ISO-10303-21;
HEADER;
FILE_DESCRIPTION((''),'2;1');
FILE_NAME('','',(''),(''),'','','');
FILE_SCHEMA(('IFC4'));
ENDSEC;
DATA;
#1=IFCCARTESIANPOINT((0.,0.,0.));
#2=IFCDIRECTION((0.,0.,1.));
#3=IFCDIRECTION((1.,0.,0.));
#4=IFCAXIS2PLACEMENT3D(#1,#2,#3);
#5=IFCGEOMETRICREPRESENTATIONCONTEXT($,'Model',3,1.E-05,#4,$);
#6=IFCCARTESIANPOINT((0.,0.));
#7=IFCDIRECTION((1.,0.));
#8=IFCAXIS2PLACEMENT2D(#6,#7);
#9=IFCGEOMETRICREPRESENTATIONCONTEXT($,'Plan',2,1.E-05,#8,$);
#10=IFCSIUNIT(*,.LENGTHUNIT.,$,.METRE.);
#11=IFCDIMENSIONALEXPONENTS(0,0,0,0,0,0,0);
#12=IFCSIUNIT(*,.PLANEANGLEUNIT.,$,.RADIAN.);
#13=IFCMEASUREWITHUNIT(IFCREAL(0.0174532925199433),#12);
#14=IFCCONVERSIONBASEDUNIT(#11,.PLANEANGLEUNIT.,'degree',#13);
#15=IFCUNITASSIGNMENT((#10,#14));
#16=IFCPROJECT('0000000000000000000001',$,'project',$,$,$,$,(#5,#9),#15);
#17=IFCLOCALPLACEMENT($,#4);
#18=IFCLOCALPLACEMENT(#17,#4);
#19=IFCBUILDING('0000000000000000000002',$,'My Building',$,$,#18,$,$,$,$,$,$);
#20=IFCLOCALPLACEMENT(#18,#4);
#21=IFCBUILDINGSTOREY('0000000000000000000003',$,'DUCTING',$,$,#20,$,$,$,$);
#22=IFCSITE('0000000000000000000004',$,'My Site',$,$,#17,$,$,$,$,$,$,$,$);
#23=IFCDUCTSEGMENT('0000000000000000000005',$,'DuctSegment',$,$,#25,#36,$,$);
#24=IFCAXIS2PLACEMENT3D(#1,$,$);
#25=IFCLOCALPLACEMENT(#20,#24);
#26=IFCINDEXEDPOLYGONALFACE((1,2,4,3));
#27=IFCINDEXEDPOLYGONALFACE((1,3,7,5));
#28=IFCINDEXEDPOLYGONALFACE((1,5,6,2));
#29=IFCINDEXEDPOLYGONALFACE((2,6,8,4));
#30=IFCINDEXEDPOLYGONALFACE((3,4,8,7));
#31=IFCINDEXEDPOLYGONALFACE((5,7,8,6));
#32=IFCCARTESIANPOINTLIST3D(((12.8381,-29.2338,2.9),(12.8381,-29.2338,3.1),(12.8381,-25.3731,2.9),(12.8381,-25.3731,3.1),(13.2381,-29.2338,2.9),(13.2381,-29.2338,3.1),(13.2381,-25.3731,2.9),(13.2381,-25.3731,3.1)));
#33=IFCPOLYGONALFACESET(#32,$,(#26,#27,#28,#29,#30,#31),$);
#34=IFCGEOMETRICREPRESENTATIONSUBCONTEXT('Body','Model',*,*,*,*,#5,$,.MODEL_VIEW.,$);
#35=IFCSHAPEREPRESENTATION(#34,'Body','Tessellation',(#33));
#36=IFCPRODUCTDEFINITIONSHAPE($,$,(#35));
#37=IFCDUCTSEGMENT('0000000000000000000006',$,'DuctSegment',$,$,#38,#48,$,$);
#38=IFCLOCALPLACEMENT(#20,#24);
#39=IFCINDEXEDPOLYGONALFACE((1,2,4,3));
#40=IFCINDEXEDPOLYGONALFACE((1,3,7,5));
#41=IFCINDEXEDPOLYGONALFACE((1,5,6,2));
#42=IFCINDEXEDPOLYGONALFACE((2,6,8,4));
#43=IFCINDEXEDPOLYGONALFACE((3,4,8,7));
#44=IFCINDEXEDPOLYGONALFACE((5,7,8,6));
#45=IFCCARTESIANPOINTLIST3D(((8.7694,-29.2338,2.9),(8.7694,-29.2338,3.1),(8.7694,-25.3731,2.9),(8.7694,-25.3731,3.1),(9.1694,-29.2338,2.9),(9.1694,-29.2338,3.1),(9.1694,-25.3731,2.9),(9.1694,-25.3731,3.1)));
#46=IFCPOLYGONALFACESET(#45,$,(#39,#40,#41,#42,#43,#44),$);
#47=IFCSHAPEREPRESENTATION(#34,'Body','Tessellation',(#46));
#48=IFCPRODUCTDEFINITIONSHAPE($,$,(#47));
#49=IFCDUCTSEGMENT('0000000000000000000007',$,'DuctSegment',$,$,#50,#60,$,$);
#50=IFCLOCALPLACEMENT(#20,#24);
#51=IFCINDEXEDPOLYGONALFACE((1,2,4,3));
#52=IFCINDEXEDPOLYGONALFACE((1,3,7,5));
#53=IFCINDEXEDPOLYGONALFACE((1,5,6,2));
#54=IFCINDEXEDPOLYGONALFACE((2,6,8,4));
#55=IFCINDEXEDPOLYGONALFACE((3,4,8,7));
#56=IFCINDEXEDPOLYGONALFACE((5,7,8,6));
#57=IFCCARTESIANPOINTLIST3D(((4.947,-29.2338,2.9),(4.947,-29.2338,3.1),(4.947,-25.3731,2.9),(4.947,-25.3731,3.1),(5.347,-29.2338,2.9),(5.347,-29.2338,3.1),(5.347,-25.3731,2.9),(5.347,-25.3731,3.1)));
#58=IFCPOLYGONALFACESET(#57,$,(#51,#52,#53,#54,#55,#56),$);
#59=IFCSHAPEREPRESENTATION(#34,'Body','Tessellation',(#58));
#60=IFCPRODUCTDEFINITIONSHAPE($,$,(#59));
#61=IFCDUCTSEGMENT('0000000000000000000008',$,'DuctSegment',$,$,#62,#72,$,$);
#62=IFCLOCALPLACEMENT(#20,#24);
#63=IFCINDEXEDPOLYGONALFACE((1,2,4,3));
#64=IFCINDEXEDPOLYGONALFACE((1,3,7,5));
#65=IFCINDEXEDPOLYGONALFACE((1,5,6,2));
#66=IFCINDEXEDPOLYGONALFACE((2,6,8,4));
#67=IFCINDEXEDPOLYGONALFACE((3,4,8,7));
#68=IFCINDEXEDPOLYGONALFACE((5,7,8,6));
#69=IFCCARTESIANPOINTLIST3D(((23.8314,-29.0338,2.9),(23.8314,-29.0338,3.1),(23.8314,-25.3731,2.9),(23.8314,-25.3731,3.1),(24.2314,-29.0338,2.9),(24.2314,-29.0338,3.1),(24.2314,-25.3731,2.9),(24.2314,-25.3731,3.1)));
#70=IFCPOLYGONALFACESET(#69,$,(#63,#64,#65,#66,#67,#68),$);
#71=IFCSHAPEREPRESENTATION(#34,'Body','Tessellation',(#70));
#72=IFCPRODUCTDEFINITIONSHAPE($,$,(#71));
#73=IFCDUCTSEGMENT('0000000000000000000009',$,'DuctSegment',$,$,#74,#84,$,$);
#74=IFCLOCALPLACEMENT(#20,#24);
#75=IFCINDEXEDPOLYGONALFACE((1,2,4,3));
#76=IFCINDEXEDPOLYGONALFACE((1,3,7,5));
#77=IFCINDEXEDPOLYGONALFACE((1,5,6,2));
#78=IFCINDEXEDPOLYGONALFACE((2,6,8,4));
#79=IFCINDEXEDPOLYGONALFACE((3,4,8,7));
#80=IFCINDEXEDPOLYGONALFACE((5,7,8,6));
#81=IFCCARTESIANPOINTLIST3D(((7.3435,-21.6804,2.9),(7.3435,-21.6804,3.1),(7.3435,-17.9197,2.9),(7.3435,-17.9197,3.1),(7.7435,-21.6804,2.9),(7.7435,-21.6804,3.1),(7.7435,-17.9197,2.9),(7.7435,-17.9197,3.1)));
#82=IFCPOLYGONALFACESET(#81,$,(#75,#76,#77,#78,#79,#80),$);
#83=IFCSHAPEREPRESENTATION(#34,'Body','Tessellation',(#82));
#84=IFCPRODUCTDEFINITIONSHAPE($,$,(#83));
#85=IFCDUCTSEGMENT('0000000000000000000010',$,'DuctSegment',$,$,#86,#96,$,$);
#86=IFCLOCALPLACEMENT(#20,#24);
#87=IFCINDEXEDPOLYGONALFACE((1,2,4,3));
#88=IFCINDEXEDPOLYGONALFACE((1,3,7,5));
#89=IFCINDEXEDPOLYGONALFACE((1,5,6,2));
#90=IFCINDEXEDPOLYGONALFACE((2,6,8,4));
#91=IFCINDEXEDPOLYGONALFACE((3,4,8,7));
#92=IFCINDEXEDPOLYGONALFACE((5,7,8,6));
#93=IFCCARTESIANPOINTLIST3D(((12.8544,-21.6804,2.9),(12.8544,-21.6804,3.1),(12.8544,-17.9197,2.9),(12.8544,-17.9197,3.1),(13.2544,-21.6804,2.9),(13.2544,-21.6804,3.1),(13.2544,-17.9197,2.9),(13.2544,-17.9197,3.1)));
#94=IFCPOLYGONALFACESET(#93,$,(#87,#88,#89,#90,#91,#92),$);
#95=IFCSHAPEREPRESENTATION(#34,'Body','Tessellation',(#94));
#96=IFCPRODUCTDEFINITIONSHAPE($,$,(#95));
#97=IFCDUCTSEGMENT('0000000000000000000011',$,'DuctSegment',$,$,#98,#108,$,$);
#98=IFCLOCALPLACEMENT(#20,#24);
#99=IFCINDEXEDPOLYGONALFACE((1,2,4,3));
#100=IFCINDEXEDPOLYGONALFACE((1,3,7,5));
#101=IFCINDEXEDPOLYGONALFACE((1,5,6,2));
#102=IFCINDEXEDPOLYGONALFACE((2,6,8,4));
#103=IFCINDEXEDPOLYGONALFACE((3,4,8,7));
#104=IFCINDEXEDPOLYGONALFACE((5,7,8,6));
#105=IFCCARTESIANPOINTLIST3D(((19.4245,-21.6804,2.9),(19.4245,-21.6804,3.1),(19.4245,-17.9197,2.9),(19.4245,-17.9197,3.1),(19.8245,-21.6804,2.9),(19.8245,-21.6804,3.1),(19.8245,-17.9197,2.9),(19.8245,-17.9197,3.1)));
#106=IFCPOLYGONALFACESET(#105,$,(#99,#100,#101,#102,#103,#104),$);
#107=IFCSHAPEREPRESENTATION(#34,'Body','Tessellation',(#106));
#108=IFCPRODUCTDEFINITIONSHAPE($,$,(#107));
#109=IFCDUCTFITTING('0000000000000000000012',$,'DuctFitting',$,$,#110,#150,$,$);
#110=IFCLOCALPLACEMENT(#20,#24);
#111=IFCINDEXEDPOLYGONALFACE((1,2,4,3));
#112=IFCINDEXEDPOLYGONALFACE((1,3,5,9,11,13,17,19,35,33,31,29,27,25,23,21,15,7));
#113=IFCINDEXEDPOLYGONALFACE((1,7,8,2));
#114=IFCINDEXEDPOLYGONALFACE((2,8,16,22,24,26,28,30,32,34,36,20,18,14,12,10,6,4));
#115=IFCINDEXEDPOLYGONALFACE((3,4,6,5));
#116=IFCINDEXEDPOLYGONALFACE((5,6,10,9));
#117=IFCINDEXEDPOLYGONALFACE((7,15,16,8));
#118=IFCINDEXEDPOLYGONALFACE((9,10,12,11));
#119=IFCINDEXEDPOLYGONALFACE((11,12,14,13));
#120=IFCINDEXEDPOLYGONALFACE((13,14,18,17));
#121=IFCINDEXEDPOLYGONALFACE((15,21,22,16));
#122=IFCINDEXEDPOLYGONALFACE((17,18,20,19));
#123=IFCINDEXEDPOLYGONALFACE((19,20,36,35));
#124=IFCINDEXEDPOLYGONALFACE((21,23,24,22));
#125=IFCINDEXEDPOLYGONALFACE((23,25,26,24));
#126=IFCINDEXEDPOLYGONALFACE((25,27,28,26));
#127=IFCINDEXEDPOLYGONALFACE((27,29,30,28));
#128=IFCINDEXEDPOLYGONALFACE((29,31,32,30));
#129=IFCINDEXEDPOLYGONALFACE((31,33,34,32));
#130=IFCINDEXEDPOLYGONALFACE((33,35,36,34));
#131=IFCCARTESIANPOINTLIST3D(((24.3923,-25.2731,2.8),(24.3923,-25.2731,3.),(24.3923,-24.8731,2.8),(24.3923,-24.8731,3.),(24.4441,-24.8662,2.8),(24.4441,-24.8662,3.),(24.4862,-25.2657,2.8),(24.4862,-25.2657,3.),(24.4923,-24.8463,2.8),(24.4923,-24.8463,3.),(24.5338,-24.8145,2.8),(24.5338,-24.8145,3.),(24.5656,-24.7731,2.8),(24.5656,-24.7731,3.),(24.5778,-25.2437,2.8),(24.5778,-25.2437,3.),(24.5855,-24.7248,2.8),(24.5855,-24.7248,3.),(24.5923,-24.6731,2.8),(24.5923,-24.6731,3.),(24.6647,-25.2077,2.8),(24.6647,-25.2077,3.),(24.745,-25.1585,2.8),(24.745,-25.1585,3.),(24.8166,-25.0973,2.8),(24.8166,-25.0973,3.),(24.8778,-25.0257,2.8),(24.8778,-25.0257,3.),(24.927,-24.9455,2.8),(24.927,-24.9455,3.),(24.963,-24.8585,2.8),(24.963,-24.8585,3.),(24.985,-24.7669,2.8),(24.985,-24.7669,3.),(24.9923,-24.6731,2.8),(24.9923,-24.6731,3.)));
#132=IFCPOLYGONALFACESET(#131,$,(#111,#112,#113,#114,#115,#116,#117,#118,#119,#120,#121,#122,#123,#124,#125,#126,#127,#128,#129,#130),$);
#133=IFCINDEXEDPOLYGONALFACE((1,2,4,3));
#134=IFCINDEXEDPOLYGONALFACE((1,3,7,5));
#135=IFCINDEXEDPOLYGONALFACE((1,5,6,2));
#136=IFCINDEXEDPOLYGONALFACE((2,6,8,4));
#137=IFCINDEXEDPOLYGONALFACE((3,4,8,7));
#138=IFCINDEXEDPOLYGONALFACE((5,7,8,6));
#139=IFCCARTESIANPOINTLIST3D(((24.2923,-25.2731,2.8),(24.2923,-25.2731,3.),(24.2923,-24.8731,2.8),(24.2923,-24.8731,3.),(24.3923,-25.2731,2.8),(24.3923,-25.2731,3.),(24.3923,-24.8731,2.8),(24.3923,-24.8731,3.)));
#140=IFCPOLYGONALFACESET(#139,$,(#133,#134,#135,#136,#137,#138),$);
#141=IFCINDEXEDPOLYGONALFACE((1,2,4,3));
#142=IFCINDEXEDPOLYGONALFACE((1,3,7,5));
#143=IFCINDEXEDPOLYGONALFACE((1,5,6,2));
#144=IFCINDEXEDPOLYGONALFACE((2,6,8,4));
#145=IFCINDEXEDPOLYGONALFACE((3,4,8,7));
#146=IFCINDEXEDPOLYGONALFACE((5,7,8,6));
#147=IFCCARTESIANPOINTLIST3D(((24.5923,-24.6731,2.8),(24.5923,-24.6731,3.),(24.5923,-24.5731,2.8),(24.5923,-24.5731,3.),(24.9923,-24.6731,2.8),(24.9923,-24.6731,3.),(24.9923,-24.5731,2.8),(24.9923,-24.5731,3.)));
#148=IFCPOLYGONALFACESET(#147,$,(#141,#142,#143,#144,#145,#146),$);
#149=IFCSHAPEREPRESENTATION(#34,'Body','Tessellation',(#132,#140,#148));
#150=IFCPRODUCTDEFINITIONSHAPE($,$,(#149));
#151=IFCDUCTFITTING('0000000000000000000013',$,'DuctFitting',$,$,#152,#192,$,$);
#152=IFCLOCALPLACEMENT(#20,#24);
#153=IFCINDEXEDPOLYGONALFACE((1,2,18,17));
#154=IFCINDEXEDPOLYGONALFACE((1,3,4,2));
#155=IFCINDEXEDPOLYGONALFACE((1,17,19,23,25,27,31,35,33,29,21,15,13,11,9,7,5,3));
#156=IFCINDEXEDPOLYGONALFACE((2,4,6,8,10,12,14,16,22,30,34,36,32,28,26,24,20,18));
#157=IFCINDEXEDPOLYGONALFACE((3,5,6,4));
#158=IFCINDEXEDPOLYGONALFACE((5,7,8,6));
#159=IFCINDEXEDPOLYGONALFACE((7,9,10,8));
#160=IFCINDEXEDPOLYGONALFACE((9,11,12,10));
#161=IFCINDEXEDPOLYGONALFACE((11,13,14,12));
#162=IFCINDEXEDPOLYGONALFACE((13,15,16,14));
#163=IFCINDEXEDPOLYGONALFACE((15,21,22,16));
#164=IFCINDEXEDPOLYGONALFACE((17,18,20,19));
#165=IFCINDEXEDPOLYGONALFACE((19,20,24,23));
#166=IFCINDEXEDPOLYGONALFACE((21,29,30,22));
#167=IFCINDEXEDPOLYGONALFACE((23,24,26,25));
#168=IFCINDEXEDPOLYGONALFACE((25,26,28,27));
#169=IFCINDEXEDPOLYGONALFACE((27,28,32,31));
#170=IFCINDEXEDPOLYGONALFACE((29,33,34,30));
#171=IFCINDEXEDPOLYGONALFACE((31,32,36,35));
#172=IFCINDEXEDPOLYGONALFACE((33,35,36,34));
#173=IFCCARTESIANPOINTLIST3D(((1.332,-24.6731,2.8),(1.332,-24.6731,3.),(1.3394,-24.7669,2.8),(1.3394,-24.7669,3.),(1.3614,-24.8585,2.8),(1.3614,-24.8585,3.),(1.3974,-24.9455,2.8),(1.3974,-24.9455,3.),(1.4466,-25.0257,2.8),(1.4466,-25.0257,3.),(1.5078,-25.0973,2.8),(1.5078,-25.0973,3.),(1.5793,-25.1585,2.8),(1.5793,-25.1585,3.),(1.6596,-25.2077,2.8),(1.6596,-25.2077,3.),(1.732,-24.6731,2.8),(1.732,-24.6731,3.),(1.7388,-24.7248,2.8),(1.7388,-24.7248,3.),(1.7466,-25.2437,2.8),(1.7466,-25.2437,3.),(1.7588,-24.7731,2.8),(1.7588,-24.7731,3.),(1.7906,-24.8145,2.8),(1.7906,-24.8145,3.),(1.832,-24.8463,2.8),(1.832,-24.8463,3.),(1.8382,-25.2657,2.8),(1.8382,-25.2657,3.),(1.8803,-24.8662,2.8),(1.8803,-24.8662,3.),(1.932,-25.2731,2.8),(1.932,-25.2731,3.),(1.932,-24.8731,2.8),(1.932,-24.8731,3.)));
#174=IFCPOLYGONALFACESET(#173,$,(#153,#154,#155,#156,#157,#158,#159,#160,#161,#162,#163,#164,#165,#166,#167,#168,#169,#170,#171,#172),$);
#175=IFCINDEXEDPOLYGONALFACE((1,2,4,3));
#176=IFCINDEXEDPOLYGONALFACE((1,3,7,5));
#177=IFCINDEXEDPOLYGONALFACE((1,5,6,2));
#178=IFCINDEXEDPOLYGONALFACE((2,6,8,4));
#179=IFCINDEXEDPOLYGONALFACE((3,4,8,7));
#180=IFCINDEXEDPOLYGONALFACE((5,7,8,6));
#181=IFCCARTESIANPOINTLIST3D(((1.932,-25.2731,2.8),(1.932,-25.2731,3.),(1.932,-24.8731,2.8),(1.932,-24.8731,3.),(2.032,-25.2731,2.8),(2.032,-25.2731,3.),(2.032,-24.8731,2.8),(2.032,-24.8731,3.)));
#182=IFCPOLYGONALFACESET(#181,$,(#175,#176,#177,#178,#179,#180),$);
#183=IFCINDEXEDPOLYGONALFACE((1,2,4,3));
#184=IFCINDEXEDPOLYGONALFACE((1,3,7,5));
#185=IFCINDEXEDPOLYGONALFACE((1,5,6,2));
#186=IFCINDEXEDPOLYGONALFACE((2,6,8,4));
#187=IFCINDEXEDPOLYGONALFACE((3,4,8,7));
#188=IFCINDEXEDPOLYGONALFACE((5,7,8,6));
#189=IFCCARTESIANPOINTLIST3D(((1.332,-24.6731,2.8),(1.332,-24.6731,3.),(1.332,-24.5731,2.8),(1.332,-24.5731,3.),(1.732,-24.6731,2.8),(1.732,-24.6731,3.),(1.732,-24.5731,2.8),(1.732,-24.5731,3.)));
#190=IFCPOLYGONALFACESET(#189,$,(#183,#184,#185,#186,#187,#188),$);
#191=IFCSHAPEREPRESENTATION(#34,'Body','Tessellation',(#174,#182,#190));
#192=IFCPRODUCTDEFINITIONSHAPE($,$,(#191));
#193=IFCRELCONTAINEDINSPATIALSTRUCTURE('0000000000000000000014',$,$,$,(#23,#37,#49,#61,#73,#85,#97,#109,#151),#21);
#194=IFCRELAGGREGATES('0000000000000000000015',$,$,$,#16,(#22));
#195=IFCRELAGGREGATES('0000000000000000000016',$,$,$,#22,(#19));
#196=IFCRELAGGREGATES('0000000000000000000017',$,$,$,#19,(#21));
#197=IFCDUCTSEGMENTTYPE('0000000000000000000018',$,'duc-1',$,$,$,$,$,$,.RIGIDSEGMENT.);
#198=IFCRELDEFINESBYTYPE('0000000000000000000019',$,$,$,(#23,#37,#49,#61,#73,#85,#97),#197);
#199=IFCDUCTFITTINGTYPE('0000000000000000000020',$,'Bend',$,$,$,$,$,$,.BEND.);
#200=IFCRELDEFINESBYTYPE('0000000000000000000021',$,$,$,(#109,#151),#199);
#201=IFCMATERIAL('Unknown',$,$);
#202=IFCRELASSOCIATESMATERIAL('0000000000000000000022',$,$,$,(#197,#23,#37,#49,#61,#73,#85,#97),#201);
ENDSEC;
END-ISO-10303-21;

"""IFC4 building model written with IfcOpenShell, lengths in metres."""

from ifc_helpers import new_model, entity, si_unit, converted_unit, frame, origin_with_axes, origin_2d_with_axis, place, context, subcontext, project, spatial, line, arc, indexed_curve, rectangle, outline, extrude, source, transform, mapped, material, material_profile, profile_set, profile_usage, type_object, type_shapes, element, save


model = new_model("IFC4")

# Units and contexts
model_context = context("Model", 3, precision=1e-05, world=origin_with_axes())
plan_context = context("Plan", 2, precision=1e-05, world=origin_2d_with_axis())
body_context = subcontext(model_context, "Body", "Model", "MODEL_VIEW")
ifc_project = project(units=[si_unit("LENGTHUNIT", "METRE"), converted_unit("PLANEANGLEUNIT", "degree", entity("IfcReal", 0.0174532925199433), si_unit("PLANEANGLEUNIT", "RADIAN"), dimensions=[0, 0, 0, 0, 0, 0, 0])], contexts=[model_context, plan_context])

# Site, building, storey
site_placement = place(None, origin_with_axes())
site = spatial("IfcSite", under=ifc_project, at=site_placement, Name="My Site")
building_placement = place(site_placement, origin_with_axes())
building = spatial("IfcBuilding", under=site, at=building_placement, Name="My Building")
storey_placement = place(building_placement, origin_with_axes())
storey = spatial("IfcBuildingStorey", under=building, at=storey_placement, Name="DUCTING")

# Duct segments
ifc_material = material(Name="Unknown")
ifc_material_profile_1 = material_profile(ifc_material, rectangle(XDim=0.4, YDim=0.2))
ifc_profile_set_1 = profile_set([ifc_material_profile_1])
duct_segment_type = type_object("IfcDuctSegmentType", Name="duc-1", PredefinedType="RIGIDSEGMENT", material=ifc_profile_set_1)
ifc_profile_usage_1 = profile_usage(ifc_profile_set_1, cardinal=5)
duct_segment_1_placement = place(storey_placement, frame((13.0381, -29.2338, 3.0), z_axis=(0.0, 1.0, 0.0), x_axis=(-1.0, 0.0, 0.0)))
element("IfcDuctSegment", 1, at=duct_segment_1_placement, inside=storey, type_object=duct_segment_type, material=ifc_profile_usage_1, Name="DuctSegment", context=body_context, shape_type="SweptSolid", body=[
    extrude(rectangle(XDim=0.4, YDim=0.2), origin_with_axes(), (0.0, 0.0, 1.0), 3.8608),
])
ifc_profile_usage_2 = profile_usage(ifc_profile_set_1, cardinal=5)
duct_segment_2_placement = place(storey_placement, frame((8.9694, -29.2338, 3.0), z_axis=(0.0, 1.0, 0.0), x_axis=(-1.0, 0.0, 0.0)))
element("IfcDuctSegment", 2, at=duct_segment_2_placement, inside=storey, type_object=duct_segment_type, material=ifc_profile_usage_2, Name="DuctSegment", context=body_context, shape_type="SweptSolid", body=[
    extrude(rectangle(XDim=0.4, YDim=0.2), origin_with_axes(), (0.0, 0.0, 1.0), 3.8608),
])
ifc_profile_usage_3 = profile_usage(ifc_profile_set_1, cardinal=5)
duct_segment_3_placement = place(storey_placement, frame((5.147, -29.2338, 3.0), z_axis=(0.0, 1.0, 0.0), x_axis=(-1.0, 0.0, 0.0)))
element("IfcDuctSegment", 3, at=duct_segment_3_placement, inside=storey, type_object=duct_segment_type, material=ifc_profile_usage_3, Name="DuctSegment", context=body_context, shape_type="SweptSolid", body=[
    extrude(rectangle(XDim=0.4, YDim=0.2), origin_with_axes(), (0.0, 0.0, 1.0), 3.8608),
])
ifc_profile_usage_4 = profile_usage(ifc_profile_set_1, cardinal=5)
duct_segment_4_placement = place(storey_placement, frame((24.0314, -29.0338, 3.0), z_axis=(0.0, 1.0, 0.0), x_axis=(-1.0, 0.0, 0.0)))
element("IfcDuctSegment", 4, at=duct_segment_4_placement, inside=storey, type_object=duct_segment_type, material=ifc_profile_usage_4, Name="DuctSegment", context=body_context, shape_type="SweptSolid", body=[
    extrude(rectangle(XDim=0.4, YDim=0.2), origin_with_axes(), (0.0, 0.0, 1.0), 3.6608),
])
ifc_profile_usage_5 = profile_usage(ifc_profile_set_1, cardinal=5)
duct_segment_5_placement = place(storey_placement, frame((7.5435, -21.6804, 3.0), z_axis=(0.0, 1.0, 0.0), x_axis=(-1.0, 0.0, 0.0)))
element("IfcDuctSegment", 5, at=duct_segment_5_placement, inside=storey, type_object=duct_segment_type, material=ifc_profile_usage_5, Name="DuctSegment", context=body_context, shape_type="SweptSolid", body=[
    extrude(rectangle(XDim=0.4, YDim=0.2), origin_with_axes(), (0.0, 0.0, 1.0), 3.7608),
])
ifc_profile_usage_6 = profile_usage(ifc_profile_set_1, cardinal=5)
duct_segment_6_placement = place(storey_placement, frame((13.0544, -21.6804, 3.0), z_axis=(0.0, 1.0, 0.0), x_axis=(-1.0, 0.0, 0.0)))
element("IfcDuctSegment", 6, at=duct_segment_6_placement, inside=storey, type_object=duct_segment_type, material=ifc_profile_usage_6, Name="DuctSegment", context=body_context, shape_type="SweptSolid", body=[
    extrude(rectangle(XDim=0.4, YDim=0.2), origin_with_axes(), (0.0, 0.0, 1.0), 3.7608),
])
ifc_profile_usage_7 = profile_usage(ifc_profile_set_1, cardinal=5)
duct_segment_7_placement = place(storey_placement, frame((19.6245, -21.6804, 3.0), z_axis=(0.0, 1.0, 0.0), x_axis=(-1.0, 0.0, 0.0)))
element("IfcDuctSegment", 7, at=duct_segment_7_placement, inside=storey, type_object=duct_segment_type, material=ifc_profile_usage_7, Name="DuctSegment", context=body_context, shape_type="SweptSolid", body=[
    extrude(rectangle(XDim=0.4, YDim=0.2), origin_with_axes(), (0.0, 0.0, 1.0), 3.7608),
])

# Duct fittings
duct_fitting_type_1 = type_object("IfcDuctFittingType", Name="Bend", PredefinedType="BEND")
shared_shape = source(origin_with_axes(), body_context, "Body", "SweptSolid", [
    extrude(outline(indexed_curve([(-0.2, 0.0), (-0.2586, -0.1414), (-0.4, -0.2), (-0.4, -0.6), (0.0243, -0.4243), (0.2, 0.0)], segments=[arc(1, 2, 3), line(3, 4), arc(4, 5, 6), line(6, 1)])), frame((0.0, -0.1, -0.1), z_axis=(0.0, -1.0, 0.0), x_axis=(1.0, 0.0, 0.0)), (0.0, 0.0, -1.0), 0.2),
    extrude(rectangle(XDim=0.4, YDim=0.2), origin_with_axes(), (0.0, 0.0, -1.0), 0.1),
    extrude(rectangle(XDim=0.4, YDim=0.2), frame((-0.4, 0.0, -0.5), z_axis=(-1.0, 0.0, 0.0), x_axis=(0.0, 0.0, -1.0)), (0.0, 0.0, 1.0), 0.1),
])
type_shapes(duct_fitting_type_1, [shared_shape])
for number, where, z_axis, x_axis, name in (
    (8, (24.2923, -25.0731, 2.9), (-1.0, 0.0, 0.0), (0.0, -1.0, 0.0), "DuctFitting"),
    (9, (2.032, -25.0731, 2.9), (1.0, 0.0, 0.0), (0.0, -1.0, 0.0), "DuctFitting"),
):
    element("IfcDuctFitting", number, at=place(storey_placement, frame(where, z_axis=z_axis, x_axis=x_axis)), inside=storey, type_object=duct_fitting_type_1, Name=name, context=body_context, shape_type="MappedRepresentation", body=[
        mapped(shared_shape, transform((0.0, 0.0, 0.0), x_axis=(1.0, 0.0, 0.0), y_axis=(0.0, 1.0, 0.0), z_axis=(0.0, 0.0, 1.0), scale=1.0)),
    ])

save(model, "model.ifc")
